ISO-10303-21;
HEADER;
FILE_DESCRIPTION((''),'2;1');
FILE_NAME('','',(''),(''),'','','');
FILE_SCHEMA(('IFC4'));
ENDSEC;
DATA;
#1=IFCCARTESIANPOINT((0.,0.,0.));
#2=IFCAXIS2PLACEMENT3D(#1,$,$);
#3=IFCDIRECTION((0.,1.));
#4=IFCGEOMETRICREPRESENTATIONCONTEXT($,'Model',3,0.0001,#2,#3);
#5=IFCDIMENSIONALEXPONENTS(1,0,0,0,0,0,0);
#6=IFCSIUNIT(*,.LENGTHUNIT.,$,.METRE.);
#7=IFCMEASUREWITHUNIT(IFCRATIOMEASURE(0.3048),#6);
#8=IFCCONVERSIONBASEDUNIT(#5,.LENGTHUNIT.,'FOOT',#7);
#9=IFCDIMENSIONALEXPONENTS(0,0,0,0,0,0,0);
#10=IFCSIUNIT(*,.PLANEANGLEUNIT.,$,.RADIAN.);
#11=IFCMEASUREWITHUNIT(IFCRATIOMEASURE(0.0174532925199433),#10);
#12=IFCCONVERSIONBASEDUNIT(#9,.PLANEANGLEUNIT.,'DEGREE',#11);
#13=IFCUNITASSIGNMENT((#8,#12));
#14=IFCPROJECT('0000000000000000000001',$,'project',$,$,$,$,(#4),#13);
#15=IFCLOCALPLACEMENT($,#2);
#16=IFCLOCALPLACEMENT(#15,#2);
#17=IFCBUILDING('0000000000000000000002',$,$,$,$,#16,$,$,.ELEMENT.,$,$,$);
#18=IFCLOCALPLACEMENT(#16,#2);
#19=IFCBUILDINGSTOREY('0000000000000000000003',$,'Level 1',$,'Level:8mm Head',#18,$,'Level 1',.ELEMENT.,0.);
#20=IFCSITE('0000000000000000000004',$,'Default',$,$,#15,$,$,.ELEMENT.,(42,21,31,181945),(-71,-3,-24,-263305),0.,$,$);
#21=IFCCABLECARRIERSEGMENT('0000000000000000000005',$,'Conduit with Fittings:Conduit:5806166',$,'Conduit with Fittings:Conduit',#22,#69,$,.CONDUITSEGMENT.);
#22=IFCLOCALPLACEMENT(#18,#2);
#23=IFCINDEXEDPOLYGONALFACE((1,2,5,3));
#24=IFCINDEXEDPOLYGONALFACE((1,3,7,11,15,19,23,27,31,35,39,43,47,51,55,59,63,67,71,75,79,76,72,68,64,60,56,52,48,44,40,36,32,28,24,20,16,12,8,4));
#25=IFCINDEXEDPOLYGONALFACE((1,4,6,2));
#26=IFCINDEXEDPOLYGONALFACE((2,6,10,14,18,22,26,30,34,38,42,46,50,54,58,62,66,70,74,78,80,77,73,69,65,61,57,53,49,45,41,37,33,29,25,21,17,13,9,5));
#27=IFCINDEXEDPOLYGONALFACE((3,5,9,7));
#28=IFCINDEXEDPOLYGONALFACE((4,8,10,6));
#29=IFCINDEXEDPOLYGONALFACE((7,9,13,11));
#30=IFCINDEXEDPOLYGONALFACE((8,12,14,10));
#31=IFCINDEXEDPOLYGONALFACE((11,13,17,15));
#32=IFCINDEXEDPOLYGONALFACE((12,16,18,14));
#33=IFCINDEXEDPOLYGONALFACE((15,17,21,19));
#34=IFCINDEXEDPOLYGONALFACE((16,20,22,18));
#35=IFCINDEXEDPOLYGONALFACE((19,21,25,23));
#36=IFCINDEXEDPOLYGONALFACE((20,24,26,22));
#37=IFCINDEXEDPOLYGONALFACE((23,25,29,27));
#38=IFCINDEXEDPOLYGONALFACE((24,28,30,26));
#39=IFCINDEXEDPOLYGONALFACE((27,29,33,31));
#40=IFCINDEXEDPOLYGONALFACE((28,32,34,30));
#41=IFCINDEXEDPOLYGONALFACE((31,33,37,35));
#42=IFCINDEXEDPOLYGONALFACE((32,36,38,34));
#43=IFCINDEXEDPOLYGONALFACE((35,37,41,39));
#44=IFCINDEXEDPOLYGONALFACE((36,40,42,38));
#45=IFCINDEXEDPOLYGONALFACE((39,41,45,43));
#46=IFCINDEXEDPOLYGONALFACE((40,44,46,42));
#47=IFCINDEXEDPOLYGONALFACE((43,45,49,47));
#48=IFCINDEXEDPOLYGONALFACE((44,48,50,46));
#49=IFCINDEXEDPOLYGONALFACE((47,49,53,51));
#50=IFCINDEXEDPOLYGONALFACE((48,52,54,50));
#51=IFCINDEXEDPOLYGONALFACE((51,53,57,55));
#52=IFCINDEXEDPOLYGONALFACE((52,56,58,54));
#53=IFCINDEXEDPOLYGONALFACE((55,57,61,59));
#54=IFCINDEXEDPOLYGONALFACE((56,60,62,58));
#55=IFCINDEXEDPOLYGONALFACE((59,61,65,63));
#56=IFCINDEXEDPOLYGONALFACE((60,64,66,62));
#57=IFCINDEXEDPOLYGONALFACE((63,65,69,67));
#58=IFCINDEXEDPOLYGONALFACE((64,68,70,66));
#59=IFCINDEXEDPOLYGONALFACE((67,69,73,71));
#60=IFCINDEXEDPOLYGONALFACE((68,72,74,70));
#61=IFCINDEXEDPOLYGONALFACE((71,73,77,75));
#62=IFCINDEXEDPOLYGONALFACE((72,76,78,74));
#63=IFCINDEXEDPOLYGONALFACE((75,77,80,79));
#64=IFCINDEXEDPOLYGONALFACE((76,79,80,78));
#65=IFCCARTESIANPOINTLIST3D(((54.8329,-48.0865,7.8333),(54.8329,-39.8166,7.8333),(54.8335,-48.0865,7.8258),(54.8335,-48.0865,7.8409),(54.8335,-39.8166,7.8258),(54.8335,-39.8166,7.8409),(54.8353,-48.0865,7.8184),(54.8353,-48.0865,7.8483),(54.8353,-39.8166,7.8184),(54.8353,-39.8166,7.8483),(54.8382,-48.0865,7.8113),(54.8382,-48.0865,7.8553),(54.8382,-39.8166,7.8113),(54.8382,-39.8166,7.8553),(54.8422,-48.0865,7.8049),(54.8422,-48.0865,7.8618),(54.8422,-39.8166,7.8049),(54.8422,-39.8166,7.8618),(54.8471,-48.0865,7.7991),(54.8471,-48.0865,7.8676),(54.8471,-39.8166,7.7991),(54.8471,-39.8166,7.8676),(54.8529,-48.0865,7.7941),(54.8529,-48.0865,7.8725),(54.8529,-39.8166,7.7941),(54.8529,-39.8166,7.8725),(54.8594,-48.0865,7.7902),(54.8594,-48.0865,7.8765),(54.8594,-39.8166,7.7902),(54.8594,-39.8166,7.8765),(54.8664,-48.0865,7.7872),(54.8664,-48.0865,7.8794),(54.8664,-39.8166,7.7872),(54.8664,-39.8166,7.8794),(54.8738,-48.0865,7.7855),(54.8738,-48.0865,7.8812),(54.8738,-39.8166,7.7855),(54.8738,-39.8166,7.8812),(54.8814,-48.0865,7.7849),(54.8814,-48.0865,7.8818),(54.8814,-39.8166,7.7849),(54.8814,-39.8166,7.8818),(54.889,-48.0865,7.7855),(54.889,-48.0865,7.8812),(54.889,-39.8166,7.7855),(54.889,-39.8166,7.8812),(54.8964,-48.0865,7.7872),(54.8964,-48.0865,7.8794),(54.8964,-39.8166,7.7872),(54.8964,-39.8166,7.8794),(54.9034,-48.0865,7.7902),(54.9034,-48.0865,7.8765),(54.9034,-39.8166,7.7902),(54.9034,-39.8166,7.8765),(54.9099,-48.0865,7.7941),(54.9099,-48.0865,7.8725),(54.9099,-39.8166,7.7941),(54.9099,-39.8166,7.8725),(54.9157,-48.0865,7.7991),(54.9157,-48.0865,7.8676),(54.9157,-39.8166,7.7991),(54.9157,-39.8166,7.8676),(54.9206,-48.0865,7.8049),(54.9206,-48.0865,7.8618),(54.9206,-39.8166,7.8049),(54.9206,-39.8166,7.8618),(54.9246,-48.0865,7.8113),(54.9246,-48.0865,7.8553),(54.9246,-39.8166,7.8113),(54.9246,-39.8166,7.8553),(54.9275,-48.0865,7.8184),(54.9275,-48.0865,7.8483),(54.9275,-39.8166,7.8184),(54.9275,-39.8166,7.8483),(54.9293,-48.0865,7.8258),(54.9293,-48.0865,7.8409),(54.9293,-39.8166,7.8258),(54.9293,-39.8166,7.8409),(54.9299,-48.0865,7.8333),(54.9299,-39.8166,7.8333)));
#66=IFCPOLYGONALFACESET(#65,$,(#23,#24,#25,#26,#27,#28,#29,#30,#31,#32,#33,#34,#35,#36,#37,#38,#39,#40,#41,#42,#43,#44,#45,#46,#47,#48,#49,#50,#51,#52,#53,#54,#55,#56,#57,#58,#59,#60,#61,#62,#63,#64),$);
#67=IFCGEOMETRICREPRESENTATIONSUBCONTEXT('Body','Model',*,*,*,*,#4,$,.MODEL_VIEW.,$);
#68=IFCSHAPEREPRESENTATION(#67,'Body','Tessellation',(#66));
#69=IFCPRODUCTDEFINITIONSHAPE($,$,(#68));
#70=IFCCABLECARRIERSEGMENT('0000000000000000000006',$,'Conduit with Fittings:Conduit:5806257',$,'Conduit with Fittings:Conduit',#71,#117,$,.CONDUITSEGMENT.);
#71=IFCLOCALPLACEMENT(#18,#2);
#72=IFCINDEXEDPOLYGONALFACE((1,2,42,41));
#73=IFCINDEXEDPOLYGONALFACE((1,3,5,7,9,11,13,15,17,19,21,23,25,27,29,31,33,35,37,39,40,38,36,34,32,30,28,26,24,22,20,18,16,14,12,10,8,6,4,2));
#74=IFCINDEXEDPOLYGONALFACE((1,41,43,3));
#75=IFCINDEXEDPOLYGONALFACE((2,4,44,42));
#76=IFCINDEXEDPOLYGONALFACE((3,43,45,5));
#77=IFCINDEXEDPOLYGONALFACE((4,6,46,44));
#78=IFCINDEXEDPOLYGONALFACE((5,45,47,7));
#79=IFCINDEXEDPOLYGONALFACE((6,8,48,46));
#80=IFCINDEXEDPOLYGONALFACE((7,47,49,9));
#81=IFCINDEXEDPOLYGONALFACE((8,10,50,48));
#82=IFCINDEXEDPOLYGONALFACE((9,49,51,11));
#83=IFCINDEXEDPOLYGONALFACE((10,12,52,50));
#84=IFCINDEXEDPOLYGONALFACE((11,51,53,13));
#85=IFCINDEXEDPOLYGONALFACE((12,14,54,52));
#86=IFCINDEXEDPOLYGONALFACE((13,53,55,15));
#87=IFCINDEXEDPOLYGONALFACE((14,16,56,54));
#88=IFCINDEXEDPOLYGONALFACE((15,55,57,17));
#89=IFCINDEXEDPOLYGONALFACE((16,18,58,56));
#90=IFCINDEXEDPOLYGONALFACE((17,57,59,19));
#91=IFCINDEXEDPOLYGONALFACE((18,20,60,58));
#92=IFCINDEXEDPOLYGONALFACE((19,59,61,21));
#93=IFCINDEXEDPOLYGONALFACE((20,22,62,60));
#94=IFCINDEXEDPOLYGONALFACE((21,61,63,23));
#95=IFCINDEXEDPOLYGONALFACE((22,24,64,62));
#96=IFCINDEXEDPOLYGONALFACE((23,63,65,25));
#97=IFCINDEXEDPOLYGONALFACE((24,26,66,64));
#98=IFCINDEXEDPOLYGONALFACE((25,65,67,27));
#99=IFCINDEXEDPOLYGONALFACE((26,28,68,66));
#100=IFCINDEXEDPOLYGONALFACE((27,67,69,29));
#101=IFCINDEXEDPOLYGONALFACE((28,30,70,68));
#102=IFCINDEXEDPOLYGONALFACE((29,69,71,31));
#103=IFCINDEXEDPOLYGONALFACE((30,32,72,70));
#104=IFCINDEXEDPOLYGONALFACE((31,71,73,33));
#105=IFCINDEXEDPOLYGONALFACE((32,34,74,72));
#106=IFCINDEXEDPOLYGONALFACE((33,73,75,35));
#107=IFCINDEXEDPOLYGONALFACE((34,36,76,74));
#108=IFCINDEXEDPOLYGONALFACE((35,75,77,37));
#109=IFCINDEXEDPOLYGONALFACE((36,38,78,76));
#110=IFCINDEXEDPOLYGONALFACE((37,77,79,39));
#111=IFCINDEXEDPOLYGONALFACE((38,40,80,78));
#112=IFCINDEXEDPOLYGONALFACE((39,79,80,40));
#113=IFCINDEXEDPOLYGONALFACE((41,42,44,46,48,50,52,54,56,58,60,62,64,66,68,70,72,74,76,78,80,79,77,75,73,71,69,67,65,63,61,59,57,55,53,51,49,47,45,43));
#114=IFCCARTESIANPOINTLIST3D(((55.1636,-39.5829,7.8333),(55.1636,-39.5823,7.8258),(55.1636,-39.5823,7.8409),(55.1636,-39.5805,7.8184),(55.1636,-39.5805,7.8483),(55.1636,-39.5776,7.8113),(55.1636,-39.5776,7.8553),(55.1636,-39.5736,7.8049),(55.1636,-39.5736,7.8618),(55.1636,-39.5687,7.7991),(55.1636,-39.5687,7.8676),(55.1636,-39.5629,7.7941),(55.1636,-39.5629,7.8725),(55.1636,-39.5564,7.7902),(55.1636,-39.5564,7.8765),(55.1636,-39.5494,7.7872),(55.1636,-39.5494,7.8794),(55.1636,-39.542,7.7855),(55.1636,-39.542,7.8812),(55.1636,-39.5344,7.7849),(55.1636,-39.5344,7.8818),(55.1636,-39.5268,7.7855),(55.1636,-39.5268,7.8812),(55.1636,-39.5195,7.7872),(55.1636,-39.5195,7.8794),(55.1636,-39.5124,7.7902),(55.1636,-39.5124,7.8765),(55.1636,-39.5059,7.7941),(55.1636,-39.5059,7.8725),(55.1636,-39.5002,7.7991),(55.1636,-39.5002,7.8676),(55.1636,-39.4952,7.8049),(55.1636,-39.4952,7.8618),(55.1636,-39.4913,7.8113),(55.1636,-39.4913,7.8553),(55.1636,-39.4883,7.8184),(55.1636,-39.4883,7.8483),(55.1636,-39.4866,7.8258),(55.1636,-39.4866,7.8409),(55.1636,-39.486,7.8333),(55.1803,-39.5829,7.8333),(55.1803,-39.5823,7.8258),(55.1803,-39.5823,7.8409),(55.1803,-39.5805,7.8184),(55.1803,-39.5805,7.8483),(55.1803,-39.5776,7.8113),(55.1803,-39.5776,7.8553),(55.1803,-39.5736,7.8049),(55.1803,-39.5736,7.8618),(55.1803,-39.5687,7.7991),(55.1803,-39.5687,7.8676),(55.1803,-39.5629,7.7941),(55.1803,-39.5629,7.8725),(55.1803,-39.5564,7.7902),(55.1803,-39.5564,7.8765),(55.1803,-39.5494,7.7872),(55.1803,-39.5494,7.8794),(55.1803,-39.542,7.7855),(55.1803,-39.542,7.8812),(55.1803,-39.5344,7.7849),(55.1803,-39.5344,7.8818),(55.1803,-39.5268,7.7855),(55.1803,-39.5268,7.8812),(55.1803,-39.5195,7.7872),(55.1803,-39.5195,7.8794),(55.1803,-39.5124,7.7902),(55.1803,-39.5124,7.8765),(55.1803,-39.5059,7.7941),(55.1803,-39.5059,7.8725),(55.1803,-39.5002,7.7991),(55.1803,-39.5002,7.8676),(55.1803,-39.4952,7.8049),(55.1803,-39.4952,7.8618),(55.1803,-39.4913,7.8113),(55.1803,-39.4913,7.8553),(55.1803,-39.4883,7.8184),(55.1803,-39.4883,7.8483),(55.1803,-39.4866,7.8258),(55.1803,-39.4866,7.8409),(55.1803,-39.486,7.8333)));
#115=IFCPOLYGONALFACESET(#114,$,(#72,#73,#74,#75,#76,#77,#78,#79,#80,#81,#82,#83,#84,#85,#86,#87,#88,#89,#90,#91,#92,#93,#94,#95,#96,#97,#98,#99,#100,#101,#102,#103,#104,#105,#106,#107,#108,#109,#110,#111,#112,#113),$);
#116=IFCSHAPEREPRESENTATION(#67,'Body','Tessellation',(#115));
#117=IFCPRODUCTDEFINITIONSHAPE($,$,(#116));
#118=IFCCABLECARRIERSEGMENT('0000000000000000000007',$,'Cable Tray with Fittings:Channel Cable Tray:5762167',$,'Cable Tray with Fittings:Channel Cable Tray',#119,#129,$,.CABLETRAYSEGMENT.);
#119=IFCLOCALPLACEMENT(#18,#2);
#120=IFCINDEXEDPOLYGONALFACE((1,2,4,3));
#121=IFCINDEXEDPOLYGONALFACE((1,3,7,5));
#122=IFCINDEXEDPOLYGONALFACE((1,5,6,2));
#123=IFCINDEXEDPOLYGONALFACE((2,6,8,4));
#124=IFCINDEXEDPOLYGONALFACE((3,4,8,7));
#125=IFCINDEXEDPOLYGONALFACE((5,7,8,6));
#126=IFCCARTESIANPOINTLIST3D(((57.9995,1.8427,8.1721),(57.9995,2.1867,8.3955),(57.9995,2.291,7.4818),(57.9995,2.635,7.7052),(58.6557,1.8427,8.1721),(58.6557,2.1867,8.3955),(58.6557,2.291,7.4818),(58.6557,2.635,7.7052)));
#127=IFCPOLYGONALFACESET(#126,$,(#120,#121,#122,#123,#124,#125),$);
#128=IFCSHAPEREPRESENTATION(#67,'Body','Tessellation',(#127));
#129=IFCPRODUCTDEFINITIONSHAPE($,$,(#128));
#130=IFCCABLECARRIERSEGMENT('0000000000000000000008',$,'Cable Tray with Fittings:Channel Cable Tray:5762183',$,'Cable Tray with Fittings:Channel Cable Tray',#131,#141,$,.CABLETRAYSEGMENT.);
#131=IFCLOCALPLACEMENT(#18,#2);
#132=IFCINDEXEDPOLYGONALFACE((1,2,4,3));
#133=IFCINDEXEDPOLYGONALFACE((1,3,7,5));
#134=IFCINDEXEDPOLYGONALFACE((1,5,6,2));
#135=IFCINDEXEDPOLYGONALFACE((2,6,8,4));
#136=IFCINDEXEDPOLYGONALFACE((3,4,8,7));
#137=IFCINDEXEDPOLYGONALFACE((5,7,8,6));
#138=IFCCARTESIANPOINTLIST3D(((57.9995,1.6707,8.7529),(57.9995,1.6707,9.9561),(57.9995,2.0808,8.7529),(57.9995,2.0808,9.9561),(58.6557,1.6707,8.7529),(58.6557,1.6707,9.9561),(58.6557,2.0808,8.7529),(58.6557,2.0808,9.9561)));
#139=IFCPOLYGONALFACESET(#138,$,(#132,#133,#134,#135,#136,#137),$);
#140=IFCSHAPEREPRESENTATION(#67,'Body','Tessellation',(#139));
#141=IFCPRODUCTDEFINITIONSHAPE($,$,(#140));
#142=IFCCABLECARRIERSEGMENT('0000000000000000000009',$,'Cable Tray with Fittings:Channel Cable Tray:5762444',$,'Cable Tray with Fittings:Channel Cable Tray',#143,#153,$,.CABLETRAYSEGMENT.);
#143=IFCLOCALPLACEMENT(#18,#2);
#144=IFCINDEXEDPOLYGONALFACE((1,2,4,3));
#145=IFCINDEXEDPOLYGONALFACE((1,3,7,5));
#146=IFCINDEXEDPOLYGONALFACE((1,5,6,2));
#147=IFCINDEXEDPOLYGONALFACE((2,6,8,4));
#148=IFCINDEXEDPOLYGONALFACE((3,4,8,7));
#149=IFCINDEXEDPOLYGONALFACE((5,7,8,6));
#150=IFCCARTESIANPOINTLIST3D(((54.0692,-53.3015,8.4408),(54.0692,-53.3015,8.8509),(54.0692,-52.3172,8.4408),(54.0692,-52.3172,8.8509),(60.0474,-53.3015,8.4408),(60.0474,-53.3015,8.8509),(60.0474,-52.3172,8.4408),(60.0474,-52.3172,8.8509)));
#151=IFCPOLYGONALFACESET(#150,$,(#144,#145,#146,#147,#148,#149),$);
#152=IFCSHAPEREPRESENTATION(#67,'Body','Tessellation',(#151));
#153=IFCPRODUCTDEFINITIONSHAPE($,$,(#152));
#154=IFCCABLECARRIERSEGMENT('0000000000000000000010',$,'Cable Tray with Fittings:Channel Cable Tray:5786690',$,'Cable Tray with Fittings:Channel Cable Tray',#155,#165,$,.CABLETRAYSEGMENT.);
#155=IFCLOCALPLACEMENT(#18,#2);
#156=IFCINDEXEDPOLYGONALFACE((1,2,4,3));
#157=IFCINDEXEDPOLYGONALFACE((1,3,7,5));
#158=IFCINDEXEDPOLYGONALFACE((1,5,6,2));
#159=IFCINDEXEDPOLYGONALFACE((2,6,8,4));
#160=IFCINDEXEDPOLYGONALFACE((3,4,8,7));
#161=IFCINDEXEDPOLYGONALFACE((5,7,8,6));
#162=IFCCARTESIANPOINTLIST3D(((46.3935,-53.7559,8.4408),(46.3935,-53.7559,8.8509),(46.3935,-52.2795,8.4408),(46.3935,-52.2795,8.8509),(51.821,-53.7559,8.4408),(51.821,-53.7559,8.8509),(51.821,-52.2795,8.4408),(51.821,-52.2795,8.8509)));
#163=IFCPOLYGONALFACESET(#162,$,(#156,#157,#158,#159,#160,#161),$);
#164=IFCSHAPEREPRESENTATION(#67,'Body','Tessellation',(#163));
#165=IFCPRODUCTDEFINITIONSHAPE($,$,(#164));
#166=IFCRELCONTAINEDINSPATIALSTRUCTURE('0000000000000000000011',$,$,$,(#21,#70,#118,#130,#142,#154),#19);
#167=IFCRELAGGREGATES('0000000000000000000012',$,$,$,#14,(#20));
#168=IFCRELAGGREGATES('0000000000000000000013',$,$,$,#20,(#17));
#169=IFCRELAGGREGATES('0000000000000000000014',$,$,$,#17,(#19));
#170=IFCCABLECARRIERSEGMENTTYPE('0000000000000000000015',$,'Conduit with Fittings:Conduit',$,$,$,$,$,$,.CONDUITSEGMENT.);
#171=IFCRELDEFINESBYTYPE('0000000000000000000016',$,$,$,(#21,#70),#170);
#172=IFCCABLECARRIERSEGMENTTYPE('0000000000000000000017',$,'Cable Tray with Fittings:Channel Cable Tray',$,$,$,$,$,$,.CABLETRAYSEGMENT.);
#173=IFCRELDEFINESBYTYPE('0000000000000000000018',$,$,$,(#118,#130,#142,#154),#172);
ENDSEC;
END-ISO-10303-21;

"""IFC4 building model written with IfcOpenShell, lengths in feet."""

from ifc_helpers import new_model, entity, si_unit, converted_unit, direction, frame, origin, place, context, subcontext, project, spatial, indexed_curve, outline, extrude, type_object, element, save


model = new_model("IFC4")

# Units and contexts
model_context = context("Model", 3, precision=0.0001, world=origin(), true_north=direction((0.0, 1.0)))
body_context = subcontext(model_context, "Body", "Model", "MODEL_VIEW")
ifc_project = project(units=[converted_unit("LENGTHUNIT", "FOOT", entity("IfcRatioMeasure", 0.3048), si_unit("LENGTHUNIT", "METRE"), dimensions=[1, 0, 0, 0, 0, 0, 0]), converted_unit("PLANEANGLEUNIT", "DEGREE", entity("IfcRatioMeasure", 0.0174532925199433), si_unit("PLANEANGLEUNIT", "RADIAN"), dimensions=[0, 0, 0, 0, 0, 0, 0])], contexts=[model_context])

# Site, building, storey
site_placement = place(None, origin())
site = spatial("IfcSite", under=ifc_project, at=site_placement, Name="Default", CompositionType="ELEMENT", RefLatitude=(42, 21, 31, 181945), RefLongitude=(-71, -3, -24, -263305), RefElevation=0.0)
building_placement = place(site_placement, origin())
building = spatial("IfcBuilding", under=site, at=building_placement, CompositionType="ELEMENT")
storey_placement = place(building_placement, origin())
storey = spatial("IfcBuildingStorey", under=building, at=storey_placement, Name="Level 1", ObjectType="Level:8mm Head", LongName="Level 1", CompositionType="ELEMENT", Elevation=0.0)

# Cable carrier segments
cable_carrier_segment_type_1 = type_object("IfcCableCarrierSegmentType", Name="Conduit with Fittings:Conduit", PredefinedType="CONDUITSEGMENT")
cable_carrier_segment_1_placement = place(storey_placement, origin())
element("IfcCableCarrierSegment", 1, at=cable_carrier_segment_1_placement, inside=storey, type_object=cable_carrier_segment_type_1, Name="Conduit with Fittings:Conduit:5806166", ObjectType="Conduit with Fittings:Conduit", PredefinedType="CONDUITSEGMENT", context=body_context, shape_type="SweptSolid", body=[
    extrude(outline(indexed_curve([(0.0485, 0.0), (0.0479, 0.0076), (0.0461, 0.015), (0.0432, 0.022), (0.0392, 0.0285), (0.0343, 0.0343), (0.0285, 0.0392), (0.022, 0.0432), (0.015, 0.0461), (0.0076, 0.0479), (0.0, 0.0485), (-0.0076, 0.0479), (-0.015, 0.0461), (-0.022, 0.0432), (-0.0285, 0.0392), (-0.0343, 0.0343), (-0.0392, 0.0285), (-0.0432, 0.022), (-0.0461, 0.015), (-0.0479, 0.0076), (-0.0485, 0.0), (-0.0479, -0.0076), (-0.0461, -0.015), (-0.0432, -0.022), (-0.0392, -0.0285), (-0.0343, -0.0343), (-0.0285, -0.0392), (-0.022, -0.0432), (-0.015, -0.0461), (-0.0076, -0.0479), (0.0, -0.0485), (0.0076, -0.0479), (0.015, -0.0461), (0.022, -0.0432), (0.0285, -0.0392), (0.0343, -0.0343), (0.0392, -0.0285), (0.0432, -0.022), (0.0461, -0.015), (0.0479, -0.0076), (0.0485, 0.0)], self_intersect=False)), frame((54.8814, -48.0865, 7.8333), z_axis=(0.0, 1.0, 0.0), x_axis=(-1.0, 0.0, 0.0)), (0.0, 0.0, 1.0), 8.2699),
])
cable_carrier_segment_2_placement = place(storey_placement, origin())
element("IfcCableCarrierSegment", 2, at=cable_carrier_segment_2_placement, inside=storey, type_object=cable_carrier_segment_type_1, Name="Conduit with Fittings:Conduit:5806257", ObjectType="Conduit with Fittings:Conduit", PredefinedType="CONDUITSEGMENT", context=body_context, shape_type="SweptSolid", body=[
    extrude(outline(indexed_curve([(0.0485, 0.0), (0.0479, 0.0076), (0.0461, 0.015), (0.0432, 0.022), (0.0392, 0.0285), (0.0343, 0.0343), (0.0285, 0.0392), (0.022, 0.0432), (0.015, 0.0461), (0.0076, 0.0479), (0.0, 0.0485), (-0.0076, 0.0479), (-0.015, 0.0461), (-0.022, 0.0432), (-0.0285, 0.0392), (-0.0343, 0.0343), (-0.0392, 0.0285), (-0.0432, 0.022), (-0.0461, 0.015), (-0.0479, 0.0076), (-0.0485, 0.0), (-0.0479, -0.0076), (-0.0461, -0.015), (-0.0432, -0.022), (-0.0392, -0.0285), (-0.0343, -0.0343), (-0.0285, -0.0392), (-0.022, -0.0432), (-0.015, -0.0461), (-0.0076, -0.0479), (0.0, -0.0485), (0.0076, -0.0479), (0.015, -0.0461), (0.022, -0.0432), (0.0285, -0.0392), (0.0343, -0.0343), (0.0392, -0.0285), (0.0432, -0.022), (0.0461, -0.015), (0.0479, -0.0076), (0.0485, 0.0)], self_intersect=False)), frame((55.1636, -39.5344, 7.8333), z_axis=(1.0, 0.0, 0.0), x_axis=(0.0, -1.0, 0.0)), (0.0, 0.0, 1.0), 0.0168),
])
cable_carrier_segment_type_2 = type_object("IfcCableCarrierSegmentType", Name="Cable Tray with Fittings:Channel Cable Tray", PredefinedType="CABLETRAYSEGMENT")
cable_carrier_segment_3_placement = place(storey_placement, origin())
element("IfcCableCarrierSegment", 3, at=cable_carrier_segment_3_placement, inside=storey, type_object=cable_carrier_segment_type_2, Name="Cable Tray with Fittings:Channel Cable Tray:5762167", ObjectType="Cable Tray with Fittings:Channel Cable Tray", PredefinedType="CABLETRAYSEGMENT", context=body_context, shape_type="SweptSolid", body=[
    extrude(outline(indexed_curve([(-0.3281, -0.2051), (0.3281, -0.2051), (0.3281, 0.2051), (-0.3281, 0.2051), (-0.3281, -0.2051)], self_intersect=False)), frame((58.3276, 2.463, 7.5935), z_axis=(0.0, -0.544639, 0.838671), x_axis=(-1.0, 0.0, 0.0)), (0.0, 0.0, 1.0), 0.8231),
])
cable_carrier_segment_4_placement = place(storey_placement, origin())
element("IfcCableCarrierSegment", 4, at=cable_carrier_segment_4_placement, inside=storey, type_object=cable_carrier_segment_type_2, Name="Cable Tray with Fittings:Channel Cable Tray:5762183", ObjectType="Cable Tray with Fittings:Channel Cable Tray", PredefinedType="CABLETRAYSEGMENT", context=body_context, shape_type="SweptSolid", body=[
    extrude(outline(indexed_curve([(-0.3281, -0.2051), (0.3281, -0.2051), (0.3281, 0.2051), (-0.3281, 0.2051), (-0.3281, -0.2051)], self_intersect=False)), frame((58.3276, 1.8757, 8.7529)), (0.0, 0.0, 1.0), 1.2032),
])
cable_carrier_segment_5_placement = place(storey_placement, origin())
element("IfcCableCarrierSegment", 5, at=cable_carrier_segment_5_placement, inside=storey, type_object=cable_carrier_segment_type_2, Name="Cable Tray with Fittings:Channel Cable Tray:5762444", ObjectType="Cable Tray with Fittings:Channel Cable Tray", PredefinedType="CABLETRAYSEGMENT", context=body_context, shape_type="SweptSolid", body=[
    extrude(outline(indexed_curve([(-2.9891, -0.4921), (2.9891, -0.4921), (2.9891, 0.4921), (-2.9891, 0.4921), (-2.9891, -0.4921)], self_intersect=False)), frame((57.0583, -52.8093, 8.4408)), (0.0, 0.0, 1.0), 0.4101),
])
cable_carrier_segment_6_placement = place(storey_placement, origin())
element("IfcCableCarrierSegment", 6, at=cable_carrier_segment_6_placement, inside=storey, type_object=cable_carrier_segment_type_2, Name="Cable Tray with Fittings:Channel Cable Tray:5786690", ObjectType="Cable Tray with Fittings:Channel Cable Tray", PredefinedType="CABLETRAYSEGMENT", context=body_context, shape_type="SweptSolid", body=[
    extrude(outline(indexed_curve([(-2.7137, -0.7382), (2.7137, -0.7382), (2.7137, 0.7382), (-2.7137, 0.7382), (-2.7137, -0.7382)], self_intersect=False)), frame((49.1073, -53.0177, 8.4408)), (0.0, 0.0, 1.0), 0.4101),
])

save(model, "model.ifc")
